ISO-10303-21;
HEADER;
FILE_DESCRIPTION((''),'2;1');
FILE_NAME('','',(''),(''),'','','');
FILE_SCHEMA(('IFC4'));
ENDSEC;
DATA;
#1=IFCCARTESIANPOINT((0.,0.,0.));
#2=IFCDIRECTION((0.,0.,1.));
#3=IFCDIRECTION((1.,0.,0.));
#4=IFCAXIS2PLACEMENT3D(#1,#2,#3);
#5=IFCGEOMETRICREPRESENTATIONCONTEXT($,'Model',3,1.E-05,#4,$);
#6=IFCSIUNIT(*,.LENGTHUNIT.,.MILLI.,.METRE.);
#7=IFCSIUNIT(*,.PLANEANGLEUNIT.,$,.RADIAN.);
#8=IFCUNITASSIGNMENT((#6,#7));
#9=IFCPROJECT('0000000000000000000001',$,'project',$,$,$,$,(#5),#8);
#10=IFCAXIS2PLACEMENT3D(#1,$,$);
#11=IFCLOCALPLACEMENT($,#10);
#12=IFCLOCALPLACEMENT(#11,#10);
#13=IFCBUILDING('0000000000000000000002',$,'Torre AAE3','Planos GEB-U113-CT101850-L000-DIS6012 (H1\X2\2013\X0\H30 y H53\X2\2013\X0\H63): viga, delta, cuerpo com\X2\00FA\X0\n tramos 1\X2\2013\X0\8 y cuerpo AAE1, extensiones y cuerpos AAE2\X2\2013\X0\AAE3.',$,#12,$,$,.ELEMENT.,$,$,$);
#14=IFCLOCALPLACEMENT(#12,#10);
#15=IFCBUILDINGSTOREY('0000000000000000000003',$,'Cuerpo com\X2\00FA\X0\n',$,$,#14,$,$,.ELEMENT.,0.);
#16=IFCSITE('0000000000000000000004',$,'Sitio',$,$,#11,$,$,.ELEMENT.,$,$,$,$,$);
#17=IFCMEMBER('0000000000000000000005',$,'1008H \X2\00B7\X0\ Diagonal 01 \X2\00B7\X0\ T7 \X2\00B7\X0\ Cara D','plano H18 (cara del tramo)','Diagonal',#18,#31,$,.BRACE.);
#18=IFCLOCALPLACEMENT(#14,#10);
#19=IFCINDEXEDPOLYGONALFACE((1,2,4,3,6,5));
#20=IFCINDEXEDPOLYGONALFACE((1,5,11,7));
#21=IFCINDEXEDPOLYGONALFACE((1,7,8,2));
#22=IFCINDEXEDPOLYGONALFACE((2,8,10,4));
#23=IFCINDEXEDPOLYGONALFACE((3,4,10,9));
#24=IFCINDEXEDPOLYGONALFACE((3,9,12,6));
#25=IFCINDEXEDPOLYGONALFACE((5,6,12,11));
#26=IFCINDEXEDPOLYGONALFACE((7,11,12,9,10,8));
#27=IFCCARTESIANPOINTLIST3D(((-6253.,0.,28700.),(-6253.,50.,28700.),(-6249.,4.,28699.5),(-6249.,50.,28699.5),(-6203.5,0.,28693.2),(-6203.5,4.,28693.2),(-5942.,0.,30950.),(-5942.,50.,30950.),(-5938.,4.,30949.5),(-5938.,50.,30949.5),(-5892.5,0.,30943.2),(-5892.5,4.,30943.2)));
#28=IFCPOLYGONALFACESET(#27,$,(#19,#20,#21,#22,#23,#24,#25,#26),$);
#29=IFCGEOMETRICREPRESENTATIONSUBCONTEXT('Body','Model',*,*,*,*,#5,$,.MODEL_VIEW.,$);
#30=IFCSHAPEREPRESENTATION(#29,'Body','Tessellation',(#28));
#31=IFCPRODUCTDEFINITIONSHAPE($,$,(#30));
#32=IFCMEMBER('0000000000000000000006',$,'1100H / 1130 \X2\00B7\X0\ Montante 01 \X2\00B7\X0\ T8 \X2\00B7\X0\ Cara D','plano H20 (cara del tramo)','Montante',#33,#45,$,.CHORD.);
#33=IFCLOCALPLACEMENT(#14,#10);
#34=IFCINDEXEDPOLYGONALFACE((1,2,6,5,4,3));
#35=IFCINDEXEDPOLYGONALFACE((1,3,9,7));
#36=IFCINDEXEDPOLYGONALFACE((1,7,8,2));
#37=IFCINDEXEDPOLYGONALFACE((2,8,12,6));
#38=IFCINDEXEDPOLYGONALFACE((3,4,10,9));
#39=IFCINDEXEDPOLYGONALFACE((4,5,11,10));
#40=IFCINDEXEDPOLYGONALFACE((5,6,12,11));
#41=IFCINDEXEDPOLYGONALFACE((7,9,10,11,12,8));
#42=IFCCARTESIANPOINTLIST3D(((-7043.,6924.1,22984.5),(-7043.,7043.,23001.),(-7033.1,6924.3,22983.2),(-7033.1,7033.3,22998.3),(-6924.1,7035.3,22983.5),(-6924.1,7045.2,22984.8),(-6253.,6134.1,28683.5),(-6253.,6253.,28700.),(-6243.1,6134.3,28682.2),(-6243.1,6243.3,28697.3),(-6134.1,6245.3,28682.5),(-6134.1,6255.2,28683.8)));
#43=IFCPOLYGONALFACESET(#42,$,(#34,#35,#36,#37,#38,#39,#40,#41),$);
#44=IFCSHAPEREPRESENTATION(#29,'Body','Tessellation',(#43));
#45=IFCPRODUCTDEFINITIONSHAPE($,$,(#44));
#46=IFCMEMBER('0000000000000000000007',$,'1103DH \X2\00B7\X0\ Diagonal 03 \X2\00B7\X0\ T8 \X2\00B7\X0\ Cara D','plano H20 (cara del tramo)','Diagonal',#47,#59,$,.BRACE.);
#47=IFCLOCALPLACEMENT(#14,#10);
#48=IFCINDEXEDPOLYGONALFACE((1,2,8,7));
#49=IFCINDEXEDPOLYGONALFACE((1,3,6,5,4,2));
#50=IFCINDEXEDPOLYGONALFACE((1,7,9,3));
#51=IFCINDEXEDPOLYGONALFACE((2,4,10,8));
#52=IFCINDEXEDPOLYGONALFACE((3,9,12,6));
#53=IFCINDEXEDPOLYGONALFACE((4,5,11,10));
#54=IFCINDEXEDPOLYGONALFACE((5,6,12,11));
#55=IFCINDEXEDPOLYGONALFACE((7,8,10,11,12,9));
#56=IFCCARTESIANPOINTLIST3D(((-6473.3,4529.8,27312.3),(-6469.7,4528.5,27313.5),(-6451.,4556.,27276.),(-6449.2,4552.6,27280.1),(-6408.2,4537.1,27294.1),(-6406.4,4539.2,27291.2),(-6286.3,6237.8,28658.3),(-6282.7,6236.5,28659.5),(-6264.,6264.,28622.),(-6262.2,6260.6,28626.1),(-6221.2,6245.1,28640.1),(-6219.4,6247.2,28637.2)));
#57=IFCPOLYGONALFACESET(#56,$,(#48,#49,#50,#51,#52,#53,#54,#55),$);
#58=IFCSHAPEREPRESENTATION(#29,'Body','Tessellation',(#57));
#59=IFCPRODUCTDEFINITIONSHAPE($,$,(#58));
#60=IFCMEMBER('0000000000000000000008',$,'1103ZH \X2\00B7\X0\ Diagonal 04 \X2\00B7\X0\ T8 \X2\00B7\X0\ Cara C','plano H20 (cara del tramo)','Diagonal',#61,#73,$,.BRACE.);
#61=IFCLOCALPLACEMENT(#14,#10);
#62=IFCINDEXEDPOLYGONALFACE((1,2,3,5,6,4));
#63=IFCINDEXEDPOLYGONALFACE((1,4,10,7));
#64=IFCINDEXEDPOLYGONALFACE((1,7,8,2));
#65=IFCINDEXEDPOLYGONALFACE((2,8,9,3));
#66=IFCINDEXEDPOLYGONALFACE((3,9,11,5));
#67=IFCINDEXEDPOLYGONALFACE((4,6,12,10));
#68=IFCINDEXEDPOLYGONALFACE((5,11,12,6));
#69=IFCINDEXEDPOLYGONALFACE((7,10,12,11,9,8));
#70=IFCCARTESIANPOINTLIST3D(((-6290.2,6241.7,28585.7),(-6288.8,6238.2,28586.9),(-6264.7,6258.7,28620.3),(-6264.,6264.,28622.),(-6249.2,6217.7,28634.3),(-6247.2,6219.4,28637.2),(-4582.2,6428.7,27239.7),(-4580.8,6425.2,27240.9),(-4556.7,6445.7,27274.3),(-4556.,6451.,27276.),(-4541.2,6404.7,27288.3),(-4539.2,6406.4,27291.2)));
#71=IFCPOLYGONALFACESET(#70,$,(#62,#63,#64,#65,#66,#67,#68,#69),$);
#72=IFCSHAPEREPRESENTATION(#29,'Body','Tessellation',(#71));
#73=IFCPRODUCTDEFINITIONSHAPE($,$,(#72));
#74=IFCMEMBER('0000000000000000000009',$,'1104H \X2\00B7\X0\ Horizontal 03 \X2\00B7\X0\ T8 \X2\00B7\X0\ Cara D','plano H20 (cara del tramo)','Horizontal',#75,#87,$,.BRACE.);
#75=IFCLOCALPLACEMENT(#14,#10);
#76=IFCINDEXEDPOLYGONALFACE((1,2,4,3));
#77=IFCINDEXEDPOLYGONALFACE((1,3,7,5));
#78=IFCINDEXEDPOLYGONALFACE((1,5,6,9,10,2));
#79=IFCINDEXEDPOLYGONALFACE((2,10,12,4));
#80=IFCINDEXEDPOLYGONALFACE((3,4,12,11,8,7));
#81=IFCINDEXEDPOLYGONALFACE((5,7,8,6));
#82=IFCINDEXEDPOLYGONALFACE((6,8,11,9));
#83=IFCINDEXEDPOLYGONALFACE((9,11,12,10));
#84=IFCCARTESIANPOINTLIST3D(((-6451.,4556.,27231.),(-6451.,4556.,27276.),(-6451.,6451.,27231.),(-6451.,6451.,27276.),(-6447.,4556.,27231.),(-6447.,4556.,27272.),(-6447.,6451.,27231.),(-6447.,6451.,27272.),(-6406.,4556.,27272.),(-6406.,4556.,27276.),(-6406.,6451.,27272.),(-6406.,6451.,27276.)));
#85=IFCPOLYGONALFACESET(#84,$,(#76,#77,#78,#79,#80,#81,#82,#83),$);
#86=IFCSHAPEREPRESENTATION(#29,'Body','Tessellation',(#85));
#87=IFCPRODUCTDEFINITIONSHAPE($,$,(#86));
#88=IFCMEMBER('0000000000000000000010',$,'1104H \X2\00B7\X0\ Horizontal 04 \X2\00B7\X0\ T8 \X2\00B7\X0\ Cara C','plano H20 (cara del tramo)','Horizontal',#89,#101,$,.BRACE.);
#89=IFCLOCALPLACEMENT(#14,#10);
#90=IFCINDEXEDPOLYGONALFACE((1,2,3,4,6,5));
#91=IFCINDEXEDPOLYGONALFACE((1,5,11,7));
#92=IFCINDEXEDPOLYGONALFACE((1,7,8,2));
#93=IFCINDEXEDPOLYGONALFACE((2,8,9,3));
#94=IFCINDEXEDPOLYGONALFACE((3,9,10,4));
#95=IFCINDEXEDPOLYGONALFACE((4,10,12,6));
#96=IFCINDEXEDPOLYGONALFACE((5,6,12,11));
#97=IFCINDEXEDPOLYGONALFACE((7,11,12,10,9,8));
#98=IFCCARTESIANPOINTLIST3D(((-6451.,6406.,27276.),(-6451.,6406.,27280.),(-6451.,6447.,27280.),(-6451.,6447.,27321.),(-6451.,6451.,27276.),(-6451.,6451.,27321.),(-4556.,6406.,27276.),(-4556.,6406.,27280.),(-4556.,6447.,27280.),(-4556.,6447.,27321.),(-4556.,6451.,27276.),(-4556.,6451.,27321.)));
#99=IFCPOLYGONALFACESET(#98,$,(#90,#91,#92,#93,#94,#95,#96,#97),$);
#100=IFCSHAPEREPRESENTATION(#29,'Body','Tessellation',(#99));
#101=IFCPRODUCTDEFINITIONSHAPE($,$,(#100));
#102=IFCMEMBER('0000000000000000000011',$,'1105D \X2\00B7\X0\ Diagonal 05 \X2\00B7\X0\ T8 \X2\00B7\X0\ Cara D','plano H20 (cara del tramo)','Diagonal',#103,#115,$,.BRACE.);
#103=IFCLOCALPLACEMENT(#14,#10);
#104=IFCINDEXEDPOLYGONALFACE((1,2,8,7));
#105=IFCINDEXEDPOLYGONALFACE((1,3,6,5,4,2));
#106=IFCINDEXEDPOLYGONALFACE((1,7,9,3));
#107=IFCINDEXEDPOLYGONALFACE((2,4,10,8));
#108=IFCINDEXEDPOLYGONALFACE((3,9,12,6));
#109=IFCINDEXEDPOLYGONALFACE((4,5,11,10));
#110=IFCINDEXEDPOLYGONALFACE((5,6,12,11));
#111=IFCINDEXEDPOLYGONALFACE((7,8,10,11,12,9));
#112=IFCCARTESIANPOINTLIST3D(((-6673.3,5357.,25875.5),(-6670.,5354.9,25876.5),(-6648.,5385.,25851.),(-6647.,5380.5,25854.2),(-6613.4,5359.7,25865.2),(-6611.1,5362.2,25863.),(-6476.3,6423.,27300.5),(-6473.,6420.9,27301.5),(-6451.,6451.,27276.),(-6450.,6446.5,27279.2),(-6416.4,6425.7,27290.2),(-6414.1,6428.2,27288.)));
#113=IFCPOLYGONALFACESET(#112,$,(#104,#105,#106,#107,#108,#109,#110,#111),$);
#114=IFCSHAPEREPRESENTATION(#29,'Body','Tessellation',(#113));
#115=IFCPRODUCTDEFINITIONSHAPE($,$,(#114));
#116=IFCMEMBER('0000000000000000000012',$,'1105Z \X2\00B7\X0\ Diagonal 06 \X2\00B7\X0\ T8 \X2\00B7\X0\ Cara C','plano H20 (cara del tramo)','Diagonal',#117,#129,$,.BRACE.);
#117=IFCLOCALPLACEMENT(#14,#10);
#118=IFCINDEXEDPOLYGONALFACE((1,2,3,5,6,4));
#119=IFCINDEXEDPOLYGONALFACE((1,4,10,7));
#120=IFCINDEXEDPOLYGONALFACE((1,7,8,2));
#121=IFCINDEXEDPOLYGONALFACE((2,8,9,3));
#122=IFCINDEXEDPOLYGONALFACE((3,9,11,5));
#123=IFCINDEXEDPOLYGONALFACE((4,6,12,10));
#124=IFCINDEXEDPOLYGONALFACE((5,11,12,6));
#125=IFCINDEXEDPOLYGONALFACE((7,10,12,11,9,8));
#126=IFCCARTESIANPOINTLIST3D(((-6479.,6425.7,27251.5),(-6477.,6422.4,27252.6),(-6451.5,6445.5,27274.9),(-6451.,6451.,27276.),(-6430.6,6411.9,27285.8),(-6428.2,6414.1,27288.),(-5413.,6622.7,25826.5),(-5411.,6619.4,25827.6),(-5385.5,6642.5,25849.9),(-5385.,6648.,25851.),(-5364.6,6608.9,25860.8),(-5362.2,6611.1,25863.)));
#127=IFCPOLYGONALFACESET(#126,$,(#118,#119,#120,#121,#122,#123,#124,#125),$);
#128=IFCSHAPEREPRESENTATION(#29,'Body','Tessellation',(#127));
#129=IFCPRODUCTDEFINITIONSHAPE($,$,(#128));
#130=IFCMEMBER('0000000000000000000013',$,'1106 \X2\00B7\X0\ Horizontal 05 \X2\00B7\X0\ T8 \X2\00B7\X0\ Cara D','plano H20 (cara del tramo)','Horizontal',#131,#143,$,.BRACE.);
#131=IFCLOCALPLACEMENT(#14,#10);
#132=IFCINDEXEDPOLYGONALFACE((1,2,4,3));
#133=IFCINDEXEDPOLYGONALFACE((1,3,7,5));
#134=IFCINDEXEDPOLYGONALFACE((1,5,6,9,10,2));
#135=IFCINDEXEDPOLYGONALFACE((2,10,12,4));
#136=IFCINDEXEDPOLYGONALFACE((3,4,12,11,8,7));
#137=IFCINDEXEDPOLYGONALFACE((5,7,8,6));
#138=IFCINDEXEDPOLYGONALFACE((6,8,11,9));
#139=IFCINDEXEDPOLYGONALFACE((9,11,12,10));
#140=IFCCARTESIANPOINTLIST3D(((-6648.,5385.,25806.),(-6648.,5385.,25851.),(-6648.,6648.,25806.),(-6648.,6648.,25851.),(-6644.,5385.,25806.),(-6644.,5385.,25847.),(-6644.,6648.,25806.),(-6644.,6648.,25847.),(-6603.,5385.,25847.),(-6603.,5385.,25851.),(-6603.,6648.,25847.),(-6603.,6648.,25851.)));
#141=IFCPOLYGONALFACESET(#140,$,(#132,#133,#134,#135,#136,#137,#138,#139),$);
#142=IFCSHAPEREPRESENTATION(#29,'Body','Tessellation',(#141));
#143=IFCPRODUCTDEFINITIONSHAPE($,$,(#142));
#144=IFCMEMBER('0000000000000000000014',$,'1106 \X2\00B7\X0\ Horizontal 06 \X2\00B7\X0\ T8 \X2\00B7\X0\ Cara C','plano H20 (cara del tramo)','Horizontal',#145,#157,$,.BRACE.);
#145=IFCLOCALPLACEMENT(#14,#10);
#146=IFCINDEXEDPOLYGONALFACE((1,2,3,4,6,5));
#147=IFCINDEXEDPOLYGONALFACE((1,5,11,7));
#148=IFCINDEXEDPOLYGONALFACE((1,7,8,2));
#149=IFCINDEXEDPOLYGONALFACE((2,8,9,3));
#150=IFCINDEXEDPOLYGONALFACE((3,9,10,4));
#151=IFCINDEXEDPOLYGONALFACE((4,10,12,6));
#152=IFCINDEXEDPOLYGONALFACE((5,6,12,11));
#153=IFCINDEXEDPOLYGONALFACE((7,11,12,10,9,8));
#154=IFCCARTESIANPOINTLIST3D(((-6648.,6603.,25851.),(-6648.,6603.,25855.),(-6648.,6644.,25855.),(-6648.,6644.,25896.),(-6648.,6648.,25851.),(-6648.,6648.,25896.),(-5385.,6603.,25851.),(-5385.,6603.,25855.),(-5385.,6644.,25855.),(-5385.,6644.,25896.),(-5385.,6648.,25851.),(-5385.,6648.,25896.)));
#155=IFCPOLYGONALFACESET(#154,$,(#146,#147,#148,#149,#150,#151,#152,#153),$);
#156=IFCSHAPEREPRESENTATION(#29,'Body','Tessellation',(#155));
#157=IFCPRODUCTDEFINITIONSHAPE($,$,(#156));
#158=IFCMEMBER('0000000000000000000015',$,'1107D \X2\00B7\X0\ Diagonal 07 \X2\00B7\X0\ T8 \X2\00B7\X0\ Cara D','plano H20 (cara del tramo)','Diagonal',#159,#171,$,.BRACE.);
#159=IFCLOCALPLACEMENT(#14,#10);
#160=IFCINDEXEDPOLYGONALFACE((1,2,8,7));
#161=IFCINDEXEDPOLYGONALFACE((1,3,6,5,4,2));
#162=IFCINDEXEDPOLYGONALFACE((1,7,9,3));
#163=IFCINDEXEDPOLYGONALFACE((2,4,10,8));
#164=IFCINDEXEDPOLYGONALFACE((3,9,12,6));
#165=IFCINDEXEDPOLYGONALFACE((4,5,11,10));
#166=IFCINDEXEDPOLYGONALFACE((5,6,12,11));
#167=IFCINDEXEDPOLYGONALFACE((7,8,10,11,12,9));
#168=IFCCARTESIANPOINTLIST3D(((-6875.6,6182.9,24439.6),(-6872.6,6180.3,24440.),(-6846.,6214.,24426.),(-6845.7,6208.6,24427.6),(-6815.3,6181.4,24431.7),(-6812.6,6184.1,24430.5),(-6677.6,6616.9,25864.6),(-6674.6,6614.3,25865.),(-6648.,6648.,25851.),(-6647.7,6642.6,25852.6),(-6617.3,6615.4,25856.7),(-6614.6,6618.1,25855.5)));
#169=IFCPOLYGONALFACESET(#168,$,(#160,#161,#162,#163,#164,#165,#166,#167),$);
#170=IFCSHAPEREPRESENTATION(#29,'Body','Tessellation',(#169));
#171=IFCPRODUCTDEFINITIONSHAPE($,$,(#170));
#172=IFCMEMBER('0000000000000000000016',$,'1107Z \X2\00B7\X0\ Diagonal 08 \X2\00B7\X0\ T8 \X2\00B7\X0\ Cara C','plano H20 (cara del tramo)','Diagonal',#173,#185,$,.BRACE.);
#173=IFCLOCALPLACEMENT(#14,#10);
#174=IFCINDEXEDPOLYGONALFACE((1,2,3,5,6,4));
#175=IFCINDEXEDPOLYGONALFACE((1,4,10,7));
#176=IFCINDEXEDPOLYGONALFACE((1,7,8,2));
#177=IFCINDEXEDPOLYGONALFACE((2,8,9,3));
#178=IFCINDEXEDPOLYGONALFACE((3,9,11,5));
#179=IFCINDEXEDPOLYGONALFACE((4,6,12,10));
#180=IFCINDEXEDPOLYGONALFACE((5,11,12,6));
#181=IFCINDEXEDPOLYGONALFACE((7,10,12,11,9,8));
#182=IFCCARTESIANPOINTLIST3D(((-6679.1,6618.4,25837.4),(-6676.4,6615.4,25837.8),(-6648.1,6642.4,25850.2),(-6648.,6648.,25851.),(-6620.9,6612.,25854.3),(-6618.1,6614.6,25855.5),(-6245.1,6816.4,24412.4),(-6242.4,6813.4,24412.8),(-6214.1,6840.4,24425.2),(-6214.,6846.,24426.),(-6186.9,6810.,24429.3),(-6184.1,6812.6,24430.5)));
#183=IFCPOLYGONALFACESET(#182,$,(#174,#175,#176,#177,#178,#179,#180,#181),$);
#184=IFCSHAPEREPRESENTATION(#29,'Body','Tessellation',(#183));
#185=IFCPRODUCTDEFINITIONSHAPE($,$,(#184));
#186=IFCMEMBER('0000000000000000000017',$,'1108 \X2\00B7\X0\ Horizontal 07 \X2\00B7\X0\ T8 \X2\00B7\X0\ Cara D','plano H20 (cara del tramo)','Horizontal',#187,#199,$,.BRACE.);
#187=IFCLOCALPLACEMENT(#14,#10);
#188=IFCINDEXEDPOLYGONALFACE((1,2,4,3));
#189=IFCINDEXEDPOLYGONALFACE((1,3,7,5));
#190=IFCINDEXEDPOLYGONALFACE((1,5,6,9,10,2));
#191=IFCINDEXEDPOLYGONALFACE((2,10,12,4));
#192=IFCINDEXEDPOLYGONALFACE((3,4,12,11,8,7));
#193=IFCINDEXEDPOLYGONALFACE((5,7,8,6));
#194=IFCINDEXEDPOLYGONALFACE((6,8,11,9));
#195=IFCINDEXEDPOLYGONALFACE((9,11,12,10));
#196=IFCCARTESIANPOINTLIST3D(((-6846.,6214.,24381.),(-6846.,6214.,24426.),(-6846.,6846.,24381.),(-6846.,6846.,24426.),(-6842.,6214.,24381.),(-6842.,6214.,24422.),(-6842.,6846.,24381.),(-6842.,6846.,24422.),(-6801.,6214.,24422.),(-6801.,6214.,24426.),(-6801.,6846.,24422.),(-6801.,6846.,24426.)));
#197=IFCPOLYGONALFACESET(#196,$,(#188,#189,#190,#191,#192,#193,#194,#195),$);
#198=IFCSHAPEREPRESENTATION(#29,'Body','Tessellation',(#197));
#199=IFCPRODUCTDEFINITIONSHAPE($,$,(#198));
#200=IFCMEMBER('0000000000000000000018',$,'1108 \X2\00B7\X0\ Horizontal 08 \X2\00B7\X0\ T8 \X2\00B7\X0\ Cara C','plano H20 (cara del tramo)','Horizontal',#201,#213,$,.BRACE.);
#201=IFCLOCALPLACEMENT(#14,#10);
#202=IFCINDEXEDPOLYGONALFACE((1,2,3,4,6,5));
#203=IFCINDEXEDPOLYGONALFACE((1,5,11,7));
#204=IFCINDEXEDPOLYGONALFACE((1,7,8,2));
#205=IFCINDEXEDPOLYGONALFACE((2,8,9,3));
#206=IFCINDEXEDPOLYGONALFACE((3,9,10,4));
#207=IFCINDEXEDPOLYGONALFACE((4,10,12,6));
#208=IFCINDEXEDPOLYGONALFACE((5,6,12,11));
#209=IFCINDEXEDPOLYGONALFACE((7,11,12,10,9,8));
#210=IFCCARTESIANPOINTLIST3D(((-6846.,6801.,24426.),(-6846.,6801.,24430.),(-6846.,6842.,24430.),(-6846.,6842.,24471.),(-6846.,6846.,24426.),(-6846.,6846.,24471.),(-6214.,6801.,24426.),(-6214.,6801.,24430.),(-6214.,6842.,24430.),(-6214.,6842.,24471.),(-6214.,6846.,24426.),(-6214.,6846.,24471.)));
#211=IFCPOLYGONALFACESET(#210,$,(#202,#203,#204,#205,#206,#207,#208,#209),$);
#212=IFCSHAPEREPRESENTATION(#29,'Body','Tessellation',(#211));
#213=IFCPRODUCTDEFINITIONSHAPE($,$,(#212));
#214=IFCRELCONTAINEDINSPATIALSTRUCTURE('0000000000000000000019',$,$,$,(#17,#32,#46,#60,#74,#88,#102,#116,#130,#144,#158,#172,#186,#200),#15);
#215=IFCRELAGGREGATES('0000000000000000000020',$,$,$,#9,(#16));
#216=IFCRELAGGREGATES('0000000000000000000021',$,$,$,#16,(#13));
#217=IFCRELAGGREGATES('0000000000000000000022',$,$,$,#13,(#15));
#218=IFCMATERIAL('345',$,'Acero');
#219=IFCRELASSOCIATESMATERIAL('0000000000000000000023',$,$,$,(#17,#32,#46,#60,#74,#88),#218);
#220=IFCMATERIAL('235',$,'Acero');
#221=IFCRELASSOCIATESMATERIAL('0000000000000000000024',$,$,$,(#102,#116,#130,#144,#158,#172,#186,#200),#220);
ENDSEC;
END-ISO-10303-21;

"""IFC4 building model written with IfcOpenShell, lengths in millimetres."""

from ifc_helpers import new_model, si_unit, frame, frame_2d, origin, origin_with_axes, place, context, subcontext, project, spatial, l_section, extrude, material, element, save


model = new_model("IFC4")

# Units and contexts
model_context = context("Model", 3, precision=1e-05, world=origin_with_axes())
body_context = subcontext(model_context, "Body", "Model", "MODEL_VIEW")
ifc_project = project(units=[si_unit("LENGTHUNIT", "METRE", prefix="MILLI"), si_unit("PLANEANGLEUNIT", "RADIAN")], contexts=[model_context])

# Site, building, storey
site_placement = place(None, origin())
site = spatial("IfcSite", under=ifc_project, at=site_placement, Name="Sitio", CompositionType="ELEMENT")
building_placement = place(site_placement, origin())
building = spatial("IfcBuilding", under=site, at=building_placement, Name="Torre AAE3", Description="Planos GEB-U113-CT101850-L000-DIS6012 (H1–H30 y H53–H63): viga, delta, cuerpo común tramos 1–8 y cuerpo AAE1, extensiones y cuerpos AAE2–AAE3.", CompositionType="ELEMENT")
storey_placement = place(building_placement, origin())
storey = spatial("IfcBuildingStorey", under=building, at=storey_placement, Name="Cuerpo común", CompositionType="ELEMENT", Elevation=0.0)

# Members
ifc_material_1 = material(Name="345", Category="Acero")
member_1_placement = place(storey_placement, frame((-6253.0, 0.0, 28700.0), z_axis=(0.13692, 0.0, 0.990582), x_axis=(0.990582, 0.0, -0.13692)))
element("IfcMember", 1, at=member_1_placement, inside=storey, material=ifc_material_1, Name="1008H · Diagonal 01 · T7 · Cara D", Description="plano H18 (cara del tramo)", ObjectType="Diagonal", PredefinedType="BRACE", context=body_context, shape_type="SweptSolid", body=[
    extrude(l_section(Depth=50.0, Width=50.0, Thickness=4.0, at=frame_2d((25.0, 25.0))), None, (0.0, 0.0, 1.0), 2271.4),
])
member_2_placement = place(storey_placement, frame((-6253.0, 6253.0, 28700.0), z_axis=(-0.136032, 0.136032, -0.981321), x_axis=(0.990705, 0.018678, -0.134743)))
element("IfcMember", 2, at=member_2_placement, inside=storey, material=ifc_material_1, Name="1100H / 1130 · Montante 01 · T8 · Cara D", Description="plano H20 (cara del tramo)", ObjectType="Montante", PredefinedType="CHORD", context=body_context, shape_type="SweptSolid", body=[
    extrude(l_section(Depth=120.0, Width=120.0, Thickness=10.0, at=frame_2d((60.0, 60.0))), None, (0.0, 0.0, 1.0), 5807.5),
])
for number, where, z_axis, x_axis, name in (
    (3, (-6264.0, 6264.0, 28622.0), (-0.085676, -0.782536, -0.616682), (0.891166, -0.336961, 0.303776), "1103DH · Diagonal 03 · T8 · Cara D"),
    (4, (-6264.0, 6264.0, 28622.0), (0.782536, 0.085676, -0.616682), (0.336961, -0.891166, 0.303776), "1103ZH · Diagonal 04 · T8 · Cara C"),
):
    element("IfcMember", number, at=place(storey_placement, frame(where, z_axis=z_axis, x_axis=x_axis)), inside=storey, material=ifc_material_1, Name=name, Description="plano H20 (cara del tramo)", ObjectType="Diagonal", PredefinedType="BRACE", context=body_context, shape_type="SweptSolid", body=[
        extrude(l_section(Depth=50.0, Width=50.0, Thickness=4.0, at=frame_2d((25.0, 25.0))), None, (0.0, 0.0, 1.0), 2182.6),
    ])
for number, where, z_axis, x_axis, name in (
    (5, (-6451.0, 4556.0, 27276.0), (0.0, 1.0, 0.0), (1.0, 0.0, 0.0), "1104H · Horizontal 03 · T8 · Cara D"),
    (6, (-4556.0, 6451.0, 27276.0), (-1.0, 0.0, 0.0), (0.0, -1.0, 0.0), "1104H · Horizontal 04 · T8 · Cara C"),
):
    element("IfcMember", number, at=place(storey_placement, frame(where, z_axis=z_axis, x_axis=x_axis)), inside=storey, material=ifc_material_1, Name=name, Description="plano H20 (cara del tramo)", ObjectType="Horizontal", PredefinedType="BRACE", context=body_context, shape_type="SweptSolid", body=[
        extrude(l_section(Depth=45.0, Width=45.0, Thickness=4.0, at=frame_2d((22.5, 22.5))), None, (0.0, 0.0, 1.0), 1895.0),
    ])
ifc_material_2 = material(Name="235", Category="Acero")
for number, where, z_axis, x_axis, name in (
    (7, (-6451.0, 6451.0, 27276.0), (-0.110027, -0.595374, -0.79588), (0.819305, -0.507658, 0.266499), "1105D · Diagonal 05 · T8 · Cara D"),
    (8, (-6451.0, 6451.0, 27276.0), (0.595374, 0.110027, -0.79588), (0.507658, -0.819305, 0.266499), "1105Z · Diagonal 06 · T8 · Cara C"),
):
    element("IfcMember", number, at=place(storey_placement, frame(where, z_axis=z_axis, x_axis=x_axis)), inside=storey, material=ifc_material_2, Name=name, Description="plano H20 (cara del tramo)", ObjectType="Diagonal", PredefinedType="BRACE", context=body_context, shape_type="SweptSolid", body=[
        extrude(l_section(Depth=45.0, Width=45.0, Thickness=4.0, at=frame_2d((22.5, 22.5))), None, (0.0, 0.0, 1.0), 1790.5),
    ])
for number, where, z_axis, x_axis, name in (
    (9, (-6648.0, 5385.0, 25851.0), (0.0, 1.0, 0.0), (1.0, 0.0, 0.0), "1106 · Horizontal 05 · T8 · Cara D"),
    (10, (-5385.0, 6648.0, 25851.0), (-1.0, 0.0, 0.0), (0.0, -1.0, 0.0), "1106 · Horizontal 06 · T8 · Cara C"),
):
    element("IfcMember", number, at=place(storey_placement, frame(where, z_axis=z_axis, x_axis=x_axis)), inside=storey, material=ifc_material_2, Name=name, Description="plano H20 (cara del tramo)", ObjectType="Horizontal", PredefinedType="BRACE", context=body_context, shape_type="SweptSolid", body=[
        extrude(l_section(Depth=45.0, Width=45.0, Thickness=4.0, at=frame_2d((22.5, 22.5))), None, (0.0, 0.0, 1.0), 1263.0),
    ])
for number, where, z_axis, x_axis, name in (
    (11, (-6648.0, 6648.0, 25851.0), (-0.131761, -0.288808, -0.948277), (0.741556, -0.663539, 0.099051), "1107D · Diagonal 07 · T8 · Cara D"),
    (12, (-6648.0, 6648.0, 25851.0), (0.288808, 0.131761, -0.948277), (0.663539, -0.741556, 0.099051), "1107Z · Diagonal 08 · T8 · Cara C"),
):
    element("IfcMember", number, at=place(storey_placement, frame(where, z_axis=z_axis, x_axis=x_axis)), inside=storey, material=ifc_material_2, Name=name, Description="plano H20 (cara del tramo)", ObjectType="Diagonal", PredefinedType="BRACE", context=body_context, shape_type="SweptSolid", body=[
        extrude(l_section(Depth=45.0, Width=45.0, Thickness=4.0, at=frame_2d((22.5, 22.5))), None, (0.0, 0.0, 1.0), 1502.7),
    ])
for number, where, z_axis, x_axis, name in (
    (13, (-6846.0, 6214.0, 24426.0), (0.0, 1.0, 0.0), (1.0, 0.0, 0.0), "1108 · Horizontal 07 · T8 · Cara D"),
    (14, (-6214.0, 6846.0, 24426.0), (-1.0, 0.0, 0.0), (0.0, -1.0, 0.0), "1108 · Horizontal 08 · T8 · Cara C"),
):
    element("IfcMember", number, at=place(storey_placement, frame(where, z_axis=z_axis, x_axis=x_axis)), inside=storey, material=ifc_material_2, Name=name, Description="plano H20 (cara del tramo)", ObjectType="Horizontal", PredefinedType="BRACE", context=body_context, shape_type="SweptSolid", body=[
        extrude(l_section(Depth=45.0, Width=45.0, Thickness=4.0, at=frame_2d((22.5, 22.5))), None, (0.0, 0.0, 1.0), 632.0),
    ])

save(model, "model.ifc")
